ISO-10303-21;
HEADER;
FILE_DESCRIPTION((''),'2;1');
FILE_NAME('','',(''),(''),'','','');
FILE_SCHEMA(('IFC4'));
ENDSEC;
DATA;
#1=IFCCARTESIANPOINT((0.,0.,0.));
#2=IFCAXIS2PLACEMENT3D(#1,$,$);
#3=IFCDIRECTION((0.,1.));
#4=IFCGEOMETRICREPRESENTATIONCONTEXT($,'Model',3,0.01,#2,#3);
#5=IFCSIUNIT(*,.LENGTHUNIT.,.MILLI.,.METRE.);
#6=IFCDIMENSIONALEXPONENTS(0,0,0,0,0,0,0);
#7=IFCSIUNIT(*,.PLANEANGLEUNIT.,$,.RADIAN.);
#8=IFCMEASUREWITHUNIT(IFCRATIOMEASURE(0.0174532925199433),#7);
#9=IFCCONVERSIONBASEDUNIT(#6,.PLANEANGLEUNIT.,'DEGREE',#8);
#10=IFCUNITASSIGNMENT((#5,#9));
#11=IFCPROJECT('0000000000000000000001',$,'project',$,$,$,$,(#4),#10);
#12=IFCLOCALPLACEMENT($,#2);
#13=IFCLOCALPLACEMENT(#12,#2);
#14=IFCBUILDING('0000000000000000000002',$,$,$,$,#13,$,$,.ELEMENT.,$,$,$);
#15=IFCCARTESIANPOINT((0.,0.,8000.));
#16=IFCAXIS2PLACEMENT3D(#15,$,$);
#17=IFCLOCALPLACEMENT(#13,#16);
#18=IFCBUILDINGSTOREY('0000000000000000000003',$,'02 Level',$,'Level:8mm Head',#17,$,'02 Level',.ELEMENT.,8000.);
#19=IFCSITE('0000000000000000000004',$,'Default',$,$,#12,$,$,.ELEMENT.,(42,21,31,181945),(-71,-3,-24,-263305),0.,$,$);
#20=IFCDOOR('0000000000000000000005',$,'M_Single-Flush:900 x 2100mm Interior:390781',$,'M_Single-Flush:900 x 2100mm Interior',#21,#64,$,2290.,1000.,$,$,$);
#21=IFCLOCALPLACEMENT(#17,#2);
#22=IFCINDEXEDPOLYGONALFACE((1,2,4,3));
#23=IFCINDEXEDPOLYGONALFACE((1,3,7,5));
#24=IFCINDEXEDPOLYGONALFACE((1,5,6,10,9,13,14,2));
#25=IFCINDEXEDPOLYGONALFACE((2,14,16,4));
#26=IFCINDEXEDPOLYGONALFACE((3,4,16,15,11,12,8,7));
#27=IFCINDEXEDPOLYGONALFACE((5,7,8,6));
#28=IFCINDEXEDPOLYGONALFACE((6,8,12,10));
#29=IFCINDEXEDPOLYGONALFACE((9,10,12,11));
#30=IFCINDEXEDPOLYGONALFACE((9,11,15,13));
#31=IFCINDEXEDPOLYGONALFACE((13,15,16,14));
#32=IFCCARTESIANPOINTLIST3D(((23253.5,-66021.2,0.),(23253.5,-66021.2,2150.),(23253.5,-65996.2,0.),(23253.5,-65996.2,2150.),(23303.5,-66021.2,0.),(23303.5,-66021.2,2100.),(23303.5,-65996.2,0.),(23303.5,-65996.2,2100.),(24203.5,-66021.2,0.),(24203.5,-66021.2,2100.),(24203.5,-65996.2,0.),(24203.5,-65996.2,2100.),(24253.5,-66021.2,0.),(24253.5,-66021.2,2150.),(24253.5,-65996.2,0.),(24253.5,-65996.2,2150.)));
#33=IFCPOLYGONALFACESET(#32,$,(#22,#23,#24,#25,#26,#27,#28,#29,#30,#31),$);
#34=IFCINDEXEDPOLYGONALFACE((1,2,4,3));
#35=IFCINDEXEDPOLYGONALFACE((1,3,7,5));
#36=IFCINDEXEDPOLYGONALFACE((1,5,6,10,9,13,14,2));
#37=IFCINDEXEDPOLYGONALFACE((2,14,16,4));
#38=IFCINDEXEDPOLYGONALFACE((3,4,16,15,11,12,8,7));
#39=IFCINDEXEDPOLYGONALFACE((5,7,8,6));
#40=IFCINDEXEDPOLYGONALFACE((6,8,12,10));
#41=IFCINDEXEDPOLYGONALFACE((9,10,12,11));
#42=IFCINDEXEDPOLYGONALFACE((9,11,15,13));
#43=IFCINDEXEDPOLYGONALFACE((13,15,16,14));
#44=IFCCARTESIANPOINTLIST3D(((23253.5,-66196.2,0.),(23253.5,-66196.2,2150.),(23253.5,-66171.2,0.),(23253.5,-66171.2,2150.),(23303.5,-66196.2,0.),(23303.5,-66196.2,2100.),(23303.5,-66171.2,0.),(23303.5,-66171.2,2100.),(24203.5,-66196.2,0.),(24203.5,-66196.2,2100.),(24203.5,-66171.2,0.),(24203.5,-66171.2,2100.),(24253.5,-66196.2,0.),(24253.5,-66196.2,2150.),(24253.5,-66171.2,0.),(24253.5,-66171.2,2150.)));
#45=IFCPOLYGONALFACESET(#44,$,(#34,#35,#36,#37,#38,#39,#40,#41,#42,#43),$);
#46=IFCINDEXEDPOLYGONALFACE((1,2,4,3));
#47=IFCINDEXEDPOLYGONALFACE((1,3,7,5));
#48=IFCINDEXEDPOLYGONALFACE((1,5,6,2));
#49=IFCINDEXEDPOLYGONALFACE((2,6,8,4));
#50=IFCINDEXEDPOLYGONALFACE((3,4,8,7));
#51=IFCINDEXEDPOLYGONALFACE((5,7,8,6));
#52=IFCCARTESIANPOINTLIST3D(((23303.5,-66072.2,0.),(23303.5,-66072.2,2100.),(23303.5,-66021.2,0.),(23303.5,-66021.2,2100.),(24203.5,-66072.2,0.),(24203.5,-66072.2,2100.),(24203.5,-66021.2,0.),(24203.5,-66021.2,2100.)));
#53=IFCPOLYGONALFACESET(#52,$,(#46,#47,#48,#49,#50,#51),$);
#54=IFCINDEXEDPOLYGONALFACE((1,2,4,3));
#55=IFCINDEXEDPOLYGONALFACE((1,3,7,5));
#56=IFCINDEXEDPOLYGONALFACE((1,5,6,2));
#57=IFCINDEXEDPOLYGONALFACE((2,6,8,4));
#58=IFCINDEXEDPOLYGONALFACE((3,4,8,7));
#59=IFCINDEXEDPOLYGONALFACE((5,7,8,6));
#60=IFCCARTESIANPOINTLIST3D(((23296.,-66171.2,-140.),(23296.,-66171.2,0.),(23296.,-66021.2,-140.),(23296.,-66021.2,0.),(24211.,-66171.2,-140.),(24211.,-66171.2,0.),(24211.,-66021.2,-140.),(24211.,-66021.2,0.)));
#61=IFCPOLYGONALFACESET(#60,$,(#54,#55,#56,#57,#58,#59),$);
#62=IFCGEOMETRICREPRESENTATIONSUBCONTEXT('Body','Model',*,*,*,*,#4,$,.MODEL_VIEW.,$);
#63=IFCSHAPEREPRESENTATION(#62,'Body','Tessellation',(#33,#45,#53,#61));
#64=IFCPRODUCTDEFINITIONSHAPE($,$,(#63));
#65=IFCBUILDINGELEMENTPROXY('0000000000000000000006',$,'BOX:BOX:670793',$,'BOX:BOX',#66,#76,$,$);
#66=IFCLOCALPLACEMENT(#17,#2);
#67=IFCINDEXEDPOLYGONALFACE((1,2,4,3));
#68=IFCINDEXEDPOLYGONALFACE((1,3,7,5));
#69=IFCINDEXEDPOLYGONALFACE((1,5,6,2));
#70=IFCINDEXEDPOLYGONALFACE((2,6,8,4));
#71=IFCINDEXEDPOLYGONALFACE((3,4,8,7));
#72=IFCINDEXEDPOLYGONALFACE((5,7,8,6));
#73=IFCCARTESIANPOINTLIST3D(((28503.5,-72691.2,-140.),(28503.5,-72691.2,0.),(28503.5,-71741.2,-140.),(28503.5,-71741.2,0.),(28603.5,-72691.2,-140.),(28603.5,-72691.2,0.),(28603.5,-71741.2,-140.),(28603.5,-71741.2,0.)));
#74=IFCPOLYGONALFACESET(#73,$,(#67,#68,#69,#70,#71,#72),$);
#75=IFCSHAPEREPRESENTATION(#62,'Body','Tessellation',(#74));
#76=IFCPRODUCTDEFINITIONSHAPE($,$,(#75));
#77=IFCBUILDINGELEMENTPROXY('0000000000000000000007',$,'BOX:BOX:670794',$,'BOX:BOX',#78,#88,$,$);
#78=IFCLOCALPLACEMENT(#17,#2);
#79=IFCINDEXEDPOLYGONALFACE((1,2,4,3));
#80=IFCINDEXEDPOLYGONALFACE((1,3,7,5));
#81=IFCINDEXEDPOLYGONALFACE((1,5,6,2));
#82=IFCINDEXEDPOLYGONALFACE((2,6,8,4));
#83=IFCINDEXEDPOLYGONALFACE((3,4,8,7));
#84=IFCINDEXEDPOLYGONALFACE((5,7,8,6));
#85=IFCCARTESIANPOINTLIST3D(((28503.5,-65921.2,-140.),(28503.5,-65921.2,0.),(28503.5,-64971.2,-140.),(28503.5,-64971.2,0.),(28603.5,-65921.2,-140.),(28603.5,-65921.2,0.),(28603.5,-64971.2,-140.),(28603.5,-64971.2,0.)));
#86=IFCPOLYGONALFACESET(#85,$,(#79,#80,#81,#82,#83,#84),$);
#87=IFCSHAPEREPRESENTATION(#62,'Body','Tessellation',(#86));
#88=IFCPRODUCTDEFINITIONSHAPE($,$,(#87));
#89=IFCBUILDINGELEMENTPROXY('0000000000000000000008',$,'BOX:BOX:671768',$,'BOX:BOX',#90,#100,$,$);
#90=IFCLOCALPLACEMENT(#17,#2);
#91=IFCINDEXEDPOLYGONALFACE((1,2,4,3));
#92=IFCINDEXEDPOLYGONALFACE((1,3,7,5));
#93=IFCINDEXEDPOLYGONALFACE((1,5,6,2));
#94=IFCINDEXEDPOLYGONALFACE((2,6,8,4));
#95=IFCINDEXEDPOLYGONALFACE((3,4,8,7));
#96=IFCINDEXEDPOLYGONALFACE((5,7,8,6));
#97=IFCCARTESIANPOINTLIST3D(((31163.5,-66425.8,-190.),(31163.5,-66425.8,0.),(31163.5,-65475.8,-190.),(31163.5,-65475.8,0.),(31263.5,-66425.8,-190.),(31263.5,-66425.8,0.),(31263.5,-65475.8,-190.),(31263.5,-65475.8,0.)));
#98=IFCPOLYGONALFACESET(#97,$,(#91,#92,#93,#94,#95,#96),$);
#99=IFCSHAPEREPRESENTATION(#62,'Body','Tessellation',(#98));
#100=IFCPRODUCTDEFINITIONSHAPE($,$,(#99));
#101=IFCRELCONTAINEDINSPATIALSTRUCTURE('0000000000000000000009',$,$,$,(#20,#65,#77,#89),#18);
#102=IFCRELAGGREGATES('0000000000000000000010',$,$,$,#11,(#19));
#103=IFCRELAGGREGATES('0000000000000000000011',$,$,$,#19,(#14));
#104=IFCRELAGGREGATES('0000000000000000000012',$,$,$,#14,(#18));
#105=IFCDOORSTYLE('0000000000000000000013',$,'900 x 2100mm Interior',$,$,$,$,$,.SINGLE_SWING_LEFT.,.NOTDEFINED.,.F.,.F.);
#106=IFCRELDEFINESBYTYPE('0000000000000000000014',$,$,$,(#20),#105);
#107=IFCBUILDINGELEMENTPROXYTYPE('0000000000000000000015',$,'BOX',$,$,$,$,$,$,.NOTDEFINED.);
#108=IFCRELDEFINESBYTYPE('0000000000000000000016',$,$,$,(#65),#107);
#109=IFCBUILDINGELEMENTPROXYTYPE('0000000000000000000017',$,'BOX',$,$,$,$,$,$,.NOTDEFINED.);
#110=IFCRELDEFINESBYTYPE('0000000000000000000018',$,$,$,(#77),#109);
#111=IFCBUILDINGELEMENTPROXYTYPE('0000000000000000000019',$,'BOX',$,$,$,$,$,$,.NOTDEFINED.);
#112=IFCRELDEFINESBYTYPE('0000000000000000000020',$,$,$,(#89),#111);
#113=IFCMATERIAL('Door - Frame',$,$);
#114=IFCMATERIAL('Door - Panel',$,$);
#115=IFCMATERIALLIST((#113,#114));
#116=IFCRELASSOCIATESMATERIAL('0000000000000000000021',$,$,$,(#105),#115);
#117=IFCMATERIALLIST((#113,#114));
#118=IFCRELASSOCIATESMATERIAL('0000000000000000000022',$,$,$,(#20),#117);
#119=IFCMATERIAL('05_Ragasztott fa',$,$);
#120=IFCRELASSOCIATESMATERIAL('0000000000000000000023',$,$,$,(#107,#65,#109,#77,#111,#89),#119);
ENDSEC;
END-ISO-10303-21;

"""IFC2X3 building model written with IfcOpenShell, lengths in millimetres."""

from ifc_helpers import new_model, entity, si_unit, converted_unit, direction, frame, frame_2d, origin, origin_2d_with_axis, place, context, subcontext, project, spatial, polyline, rectangle, outline, extrude, source, transform, mapped, material, material_list, type_object, type_shapes, element, save


model = new_model("IFC2X3")

# Units and contexts
model_context = context("Model", 3, precision=0.01, world=origin(), true_north=direction((0.0, 1.0)))
body_context = subcontext(model_context, "Body", "Model", "MODEL_VIEW")
ifc_project = project(units=[si_unit("LENGTHUNIT", "METRE", prefix="MILLI"), converted_unit("PLANEANGLEUNIT", "DEGREE", entity("IfcRatioMeasure", 0.0174532925199433), si_unit("PLANEANGLEUNIT", "RADIAN"), dimensions=[0, 0, 0, 0, 0, 0, 0])], contexts=[model_context])

# Site, building, storey
site_placement = place(None, origin())
site = spatial("IfcSite", under=ifc_project, at=site_placement, Name="Default", CompositionType="ELEMENT", RefLatitude=(42, 21, 31, 181945), RefLongitude=(-71, -3, -24, -263305), RefElevation=0.0)
building_placement = place(site_placement, origin())
building = spatial("IfcBuilding", under=site, at=building_placement, CompositionType="ELEMENT")
storey_placement = place(building_placement, frame((0.0, 0.0, 8000.0)))
storey = spatial("IfcBuildingStorey", under=building, at=storey_placement, Name="02 Level", ObjectType="Level:8mm Head", LongName="02 Level", CompositionType="ELEMENT", Elevation=8000.0)

# Shared definitions
ifc_material_1 = material(Name="Door - Frame")
ifc_material_2 = material(Name="Door - Panel")

# Door
ifc_material_list_1 = material_list([ifc_material_1, ifc_material_2])
ifc_material_list_2 = material_list([ifc_material_1, ifc_material_2])
door_style_1 = type_object("IfcDoorStyle", Name="900 x 2100mm Interior", ConstructionType="NOTDEFINED", OperationType="SINGLE_SWING_LEFT", ParameterTakesPrecedence=False, Sizeable=False, material=ifc_material_list_2)
shared_shape_1 = source(origin(), body_context, "Body", "SweptSolid", [
    extrude(outline(polyline([(-500.0, -1087.5), (500.0, -1087.5), (500.0, 1062.5), (450.0, 1062.5), (450.0, -1037.5), (-450.0, -1037.5), (-450.0, 1062.5), (-500.0, 1062.5), (-500.0, -1087.5)])), frame((450.0, 175.0, 1202.5), z_axis=(0.0, -1.0, 0.0), x_axis=(-1.0, 0.0, 0.0)), (0.0, 0.0, 1.0), 25.0),
    extrude(outline(polyline([(-1087.5, -500.0), (1062.5, -500.0), (1062.5, -450.0), (-1037.5, -450.0), (-1037.5, 450.0), (1062.5, 450.0), (1062.5, 500.0), (-1087.5, 500.0), (-1087.5, -500.0)])), frame((450.0, 0.0, 1202.5), z_axis=(0.0, -1.0, 0.0), x_axis=(0.0, 0.0, -1.0)), (0.0, 0.0, 1.0), 25.0),
    extrude(rectangle(XDim=900.0, YDim=51.0, at=frame_2d((0.0, 0.0), x_axis=(1.0, 0.0))), frame((450.0, 124.5, 140.0)), (0.0, 0.0, 1.0), 2100.0),
    extrude(rectangle(XDim=150.0, YDim=915.0, at=origin_2d_with_axis()), frame((450.0, 75.0, 0.0), z_axis=(0.0, 0.0, 1.0), x_axis=(0.0, -1.0, 0.0)), (0.0, 0.0, 1.0), 140.0),
])
type_shapes(door_style_1, [shared_shape_1])
door_1_placement = place(storey_placement, frame((23303.5, -66171.2, -140.0)))
element("IfcDoor", 1, at=door_1_placement, inside=storey, type_object=door_style_1, material=ifc_material_list_1, Name="M_Single-Flush:900 x 2100mm Interior:390781", ObjectType="M_Single-Flush:900 x 2100mm Interior", OverallHeight=2290.0, OverallWidth=1000.0, context=body_context, shape_type="MappedRepresentation", body=[
    mapped(shared_shape_1, transform((0.0, 0.0, 0.0), scale=1.0)),
])

# Building element proxies
ifc_material_3 = material(Name="05_Ragasztott fa")
building_element_proxy_type_1 = type_object("IfcBuildingElementProxyType", Name="BOX", PredefinedType="NOTDEFINED", material=ifc_material_3)
shared_shape_2 = source(origin(), body_context, "Body", "SweptSolid", [
    extrude(rectangle(XDim=100.0, YDim=950.0, at=frame_2d((0.0, 0.0), x_axis=(1.0, 0.0))), frame((50.0, 475.0, 0.0), z_axis=(0.0, 0.0, 1.0), x_axis=(-1.0, 0.0, 0.0)), (0.0, 0.0, 1.0), 140.0),
])
type_shapes(building_element_proxy_type_1, [shared_shape_2])
proxy_1_placement = place(storey_placement, frame((28503.5, -72691.2, -140.0)))
element("IfcBuildingElementProxy", 2, at=proxy_1_placement, inside=storey, type_object=building_element_proxy_type_1, material=ifc_material_3, Name="BOX:BOX:670793", ObjectType="BOX:BOX", context=body_context, shape_type="MappedRepresentation", body=[
    mapped(shared_shape_2, transform((0.0, 0.0, 0.0), scale=1.0)),
])
building_element_proxy_type_2 = type_object("IfcBuildingElementProxyType", Name="BOX", PredefinedType="NOTDEFINED", material=ifc_material_3)
shared_shape_3 = source(origin(), body_context, "Body", "SweptSolid", [
    extrude(rectangle(XDim=100.0, YDim=950.0, at=frame_2d((0.0, 0.0), x_axis=(1.0, 0.0))), frame((50.0, 475.0, 0.0), z_axis=(0.0, 0.0, 1.0), x_axis=(-1.0, 0.0, 0.0)), (0.0, 0.0, 1.0), 140.0),
])
type_shapes(building_element_proxy_type_2, [shared_shape_3])
proxy_2_placement = place(storey_placement, frame((28503.5, -65921.2, -140.0)))
element("IfcBuildingElementProxy", 3, at=proxy_2_placement, inside=storey, type_object=building_element_proxy_type_2, material=ifc_material_3, Name="BOX:BOX:670794", ObjectType="BOX:BOX", context=body_context, shape_type="MappedRepresentation", body=[
    mapped(shared_shape_3, transform((0.0, 0.0, 0.0), scale=1.0)),
])
building_element_proxy_type_3 = type_object("IfcBuildingElementProxyType", Name="BOX", PredefinedType="NOTDEFINED", material=ifc_material_3)
shared_shape_4 = source(origin(), body_context, "Body", "SweptSolid", [
    extrude(rectangle(XDim=100.0, YDim=950.0, at=frame_2d((0.0, 0.0), x_axis=(1.0, 0.0))), frame((50.0, 475.0, 0.0), z_axis=(0.0, 0.0, 1.0), x_axis=(-1.0, 0.0, 0.0)), (0.0, 0.0, 1.0), 190.0),
])
type_shapes(building_element_proxy_type_3, [shared_shape_4])
proxy_3_placement = place(storey_placement, frame((31163.5, -66425.8, -190.0)))
element("IfcBuildingElementProxy", 4, at=proxy_3_placement, inside=storey, type_object=building_element_proxy_type_3, material=ifc_material_3, Name="BOX:BOX:671768", ObjectType="BOX:BOX", context=body_context, shape_type="MappedRepresentation", body=[
    mapped(shared_shape_4, transform((0.0, 0.0, 0.0), scale=1.0)),
])

save(model, "model.ifc")
